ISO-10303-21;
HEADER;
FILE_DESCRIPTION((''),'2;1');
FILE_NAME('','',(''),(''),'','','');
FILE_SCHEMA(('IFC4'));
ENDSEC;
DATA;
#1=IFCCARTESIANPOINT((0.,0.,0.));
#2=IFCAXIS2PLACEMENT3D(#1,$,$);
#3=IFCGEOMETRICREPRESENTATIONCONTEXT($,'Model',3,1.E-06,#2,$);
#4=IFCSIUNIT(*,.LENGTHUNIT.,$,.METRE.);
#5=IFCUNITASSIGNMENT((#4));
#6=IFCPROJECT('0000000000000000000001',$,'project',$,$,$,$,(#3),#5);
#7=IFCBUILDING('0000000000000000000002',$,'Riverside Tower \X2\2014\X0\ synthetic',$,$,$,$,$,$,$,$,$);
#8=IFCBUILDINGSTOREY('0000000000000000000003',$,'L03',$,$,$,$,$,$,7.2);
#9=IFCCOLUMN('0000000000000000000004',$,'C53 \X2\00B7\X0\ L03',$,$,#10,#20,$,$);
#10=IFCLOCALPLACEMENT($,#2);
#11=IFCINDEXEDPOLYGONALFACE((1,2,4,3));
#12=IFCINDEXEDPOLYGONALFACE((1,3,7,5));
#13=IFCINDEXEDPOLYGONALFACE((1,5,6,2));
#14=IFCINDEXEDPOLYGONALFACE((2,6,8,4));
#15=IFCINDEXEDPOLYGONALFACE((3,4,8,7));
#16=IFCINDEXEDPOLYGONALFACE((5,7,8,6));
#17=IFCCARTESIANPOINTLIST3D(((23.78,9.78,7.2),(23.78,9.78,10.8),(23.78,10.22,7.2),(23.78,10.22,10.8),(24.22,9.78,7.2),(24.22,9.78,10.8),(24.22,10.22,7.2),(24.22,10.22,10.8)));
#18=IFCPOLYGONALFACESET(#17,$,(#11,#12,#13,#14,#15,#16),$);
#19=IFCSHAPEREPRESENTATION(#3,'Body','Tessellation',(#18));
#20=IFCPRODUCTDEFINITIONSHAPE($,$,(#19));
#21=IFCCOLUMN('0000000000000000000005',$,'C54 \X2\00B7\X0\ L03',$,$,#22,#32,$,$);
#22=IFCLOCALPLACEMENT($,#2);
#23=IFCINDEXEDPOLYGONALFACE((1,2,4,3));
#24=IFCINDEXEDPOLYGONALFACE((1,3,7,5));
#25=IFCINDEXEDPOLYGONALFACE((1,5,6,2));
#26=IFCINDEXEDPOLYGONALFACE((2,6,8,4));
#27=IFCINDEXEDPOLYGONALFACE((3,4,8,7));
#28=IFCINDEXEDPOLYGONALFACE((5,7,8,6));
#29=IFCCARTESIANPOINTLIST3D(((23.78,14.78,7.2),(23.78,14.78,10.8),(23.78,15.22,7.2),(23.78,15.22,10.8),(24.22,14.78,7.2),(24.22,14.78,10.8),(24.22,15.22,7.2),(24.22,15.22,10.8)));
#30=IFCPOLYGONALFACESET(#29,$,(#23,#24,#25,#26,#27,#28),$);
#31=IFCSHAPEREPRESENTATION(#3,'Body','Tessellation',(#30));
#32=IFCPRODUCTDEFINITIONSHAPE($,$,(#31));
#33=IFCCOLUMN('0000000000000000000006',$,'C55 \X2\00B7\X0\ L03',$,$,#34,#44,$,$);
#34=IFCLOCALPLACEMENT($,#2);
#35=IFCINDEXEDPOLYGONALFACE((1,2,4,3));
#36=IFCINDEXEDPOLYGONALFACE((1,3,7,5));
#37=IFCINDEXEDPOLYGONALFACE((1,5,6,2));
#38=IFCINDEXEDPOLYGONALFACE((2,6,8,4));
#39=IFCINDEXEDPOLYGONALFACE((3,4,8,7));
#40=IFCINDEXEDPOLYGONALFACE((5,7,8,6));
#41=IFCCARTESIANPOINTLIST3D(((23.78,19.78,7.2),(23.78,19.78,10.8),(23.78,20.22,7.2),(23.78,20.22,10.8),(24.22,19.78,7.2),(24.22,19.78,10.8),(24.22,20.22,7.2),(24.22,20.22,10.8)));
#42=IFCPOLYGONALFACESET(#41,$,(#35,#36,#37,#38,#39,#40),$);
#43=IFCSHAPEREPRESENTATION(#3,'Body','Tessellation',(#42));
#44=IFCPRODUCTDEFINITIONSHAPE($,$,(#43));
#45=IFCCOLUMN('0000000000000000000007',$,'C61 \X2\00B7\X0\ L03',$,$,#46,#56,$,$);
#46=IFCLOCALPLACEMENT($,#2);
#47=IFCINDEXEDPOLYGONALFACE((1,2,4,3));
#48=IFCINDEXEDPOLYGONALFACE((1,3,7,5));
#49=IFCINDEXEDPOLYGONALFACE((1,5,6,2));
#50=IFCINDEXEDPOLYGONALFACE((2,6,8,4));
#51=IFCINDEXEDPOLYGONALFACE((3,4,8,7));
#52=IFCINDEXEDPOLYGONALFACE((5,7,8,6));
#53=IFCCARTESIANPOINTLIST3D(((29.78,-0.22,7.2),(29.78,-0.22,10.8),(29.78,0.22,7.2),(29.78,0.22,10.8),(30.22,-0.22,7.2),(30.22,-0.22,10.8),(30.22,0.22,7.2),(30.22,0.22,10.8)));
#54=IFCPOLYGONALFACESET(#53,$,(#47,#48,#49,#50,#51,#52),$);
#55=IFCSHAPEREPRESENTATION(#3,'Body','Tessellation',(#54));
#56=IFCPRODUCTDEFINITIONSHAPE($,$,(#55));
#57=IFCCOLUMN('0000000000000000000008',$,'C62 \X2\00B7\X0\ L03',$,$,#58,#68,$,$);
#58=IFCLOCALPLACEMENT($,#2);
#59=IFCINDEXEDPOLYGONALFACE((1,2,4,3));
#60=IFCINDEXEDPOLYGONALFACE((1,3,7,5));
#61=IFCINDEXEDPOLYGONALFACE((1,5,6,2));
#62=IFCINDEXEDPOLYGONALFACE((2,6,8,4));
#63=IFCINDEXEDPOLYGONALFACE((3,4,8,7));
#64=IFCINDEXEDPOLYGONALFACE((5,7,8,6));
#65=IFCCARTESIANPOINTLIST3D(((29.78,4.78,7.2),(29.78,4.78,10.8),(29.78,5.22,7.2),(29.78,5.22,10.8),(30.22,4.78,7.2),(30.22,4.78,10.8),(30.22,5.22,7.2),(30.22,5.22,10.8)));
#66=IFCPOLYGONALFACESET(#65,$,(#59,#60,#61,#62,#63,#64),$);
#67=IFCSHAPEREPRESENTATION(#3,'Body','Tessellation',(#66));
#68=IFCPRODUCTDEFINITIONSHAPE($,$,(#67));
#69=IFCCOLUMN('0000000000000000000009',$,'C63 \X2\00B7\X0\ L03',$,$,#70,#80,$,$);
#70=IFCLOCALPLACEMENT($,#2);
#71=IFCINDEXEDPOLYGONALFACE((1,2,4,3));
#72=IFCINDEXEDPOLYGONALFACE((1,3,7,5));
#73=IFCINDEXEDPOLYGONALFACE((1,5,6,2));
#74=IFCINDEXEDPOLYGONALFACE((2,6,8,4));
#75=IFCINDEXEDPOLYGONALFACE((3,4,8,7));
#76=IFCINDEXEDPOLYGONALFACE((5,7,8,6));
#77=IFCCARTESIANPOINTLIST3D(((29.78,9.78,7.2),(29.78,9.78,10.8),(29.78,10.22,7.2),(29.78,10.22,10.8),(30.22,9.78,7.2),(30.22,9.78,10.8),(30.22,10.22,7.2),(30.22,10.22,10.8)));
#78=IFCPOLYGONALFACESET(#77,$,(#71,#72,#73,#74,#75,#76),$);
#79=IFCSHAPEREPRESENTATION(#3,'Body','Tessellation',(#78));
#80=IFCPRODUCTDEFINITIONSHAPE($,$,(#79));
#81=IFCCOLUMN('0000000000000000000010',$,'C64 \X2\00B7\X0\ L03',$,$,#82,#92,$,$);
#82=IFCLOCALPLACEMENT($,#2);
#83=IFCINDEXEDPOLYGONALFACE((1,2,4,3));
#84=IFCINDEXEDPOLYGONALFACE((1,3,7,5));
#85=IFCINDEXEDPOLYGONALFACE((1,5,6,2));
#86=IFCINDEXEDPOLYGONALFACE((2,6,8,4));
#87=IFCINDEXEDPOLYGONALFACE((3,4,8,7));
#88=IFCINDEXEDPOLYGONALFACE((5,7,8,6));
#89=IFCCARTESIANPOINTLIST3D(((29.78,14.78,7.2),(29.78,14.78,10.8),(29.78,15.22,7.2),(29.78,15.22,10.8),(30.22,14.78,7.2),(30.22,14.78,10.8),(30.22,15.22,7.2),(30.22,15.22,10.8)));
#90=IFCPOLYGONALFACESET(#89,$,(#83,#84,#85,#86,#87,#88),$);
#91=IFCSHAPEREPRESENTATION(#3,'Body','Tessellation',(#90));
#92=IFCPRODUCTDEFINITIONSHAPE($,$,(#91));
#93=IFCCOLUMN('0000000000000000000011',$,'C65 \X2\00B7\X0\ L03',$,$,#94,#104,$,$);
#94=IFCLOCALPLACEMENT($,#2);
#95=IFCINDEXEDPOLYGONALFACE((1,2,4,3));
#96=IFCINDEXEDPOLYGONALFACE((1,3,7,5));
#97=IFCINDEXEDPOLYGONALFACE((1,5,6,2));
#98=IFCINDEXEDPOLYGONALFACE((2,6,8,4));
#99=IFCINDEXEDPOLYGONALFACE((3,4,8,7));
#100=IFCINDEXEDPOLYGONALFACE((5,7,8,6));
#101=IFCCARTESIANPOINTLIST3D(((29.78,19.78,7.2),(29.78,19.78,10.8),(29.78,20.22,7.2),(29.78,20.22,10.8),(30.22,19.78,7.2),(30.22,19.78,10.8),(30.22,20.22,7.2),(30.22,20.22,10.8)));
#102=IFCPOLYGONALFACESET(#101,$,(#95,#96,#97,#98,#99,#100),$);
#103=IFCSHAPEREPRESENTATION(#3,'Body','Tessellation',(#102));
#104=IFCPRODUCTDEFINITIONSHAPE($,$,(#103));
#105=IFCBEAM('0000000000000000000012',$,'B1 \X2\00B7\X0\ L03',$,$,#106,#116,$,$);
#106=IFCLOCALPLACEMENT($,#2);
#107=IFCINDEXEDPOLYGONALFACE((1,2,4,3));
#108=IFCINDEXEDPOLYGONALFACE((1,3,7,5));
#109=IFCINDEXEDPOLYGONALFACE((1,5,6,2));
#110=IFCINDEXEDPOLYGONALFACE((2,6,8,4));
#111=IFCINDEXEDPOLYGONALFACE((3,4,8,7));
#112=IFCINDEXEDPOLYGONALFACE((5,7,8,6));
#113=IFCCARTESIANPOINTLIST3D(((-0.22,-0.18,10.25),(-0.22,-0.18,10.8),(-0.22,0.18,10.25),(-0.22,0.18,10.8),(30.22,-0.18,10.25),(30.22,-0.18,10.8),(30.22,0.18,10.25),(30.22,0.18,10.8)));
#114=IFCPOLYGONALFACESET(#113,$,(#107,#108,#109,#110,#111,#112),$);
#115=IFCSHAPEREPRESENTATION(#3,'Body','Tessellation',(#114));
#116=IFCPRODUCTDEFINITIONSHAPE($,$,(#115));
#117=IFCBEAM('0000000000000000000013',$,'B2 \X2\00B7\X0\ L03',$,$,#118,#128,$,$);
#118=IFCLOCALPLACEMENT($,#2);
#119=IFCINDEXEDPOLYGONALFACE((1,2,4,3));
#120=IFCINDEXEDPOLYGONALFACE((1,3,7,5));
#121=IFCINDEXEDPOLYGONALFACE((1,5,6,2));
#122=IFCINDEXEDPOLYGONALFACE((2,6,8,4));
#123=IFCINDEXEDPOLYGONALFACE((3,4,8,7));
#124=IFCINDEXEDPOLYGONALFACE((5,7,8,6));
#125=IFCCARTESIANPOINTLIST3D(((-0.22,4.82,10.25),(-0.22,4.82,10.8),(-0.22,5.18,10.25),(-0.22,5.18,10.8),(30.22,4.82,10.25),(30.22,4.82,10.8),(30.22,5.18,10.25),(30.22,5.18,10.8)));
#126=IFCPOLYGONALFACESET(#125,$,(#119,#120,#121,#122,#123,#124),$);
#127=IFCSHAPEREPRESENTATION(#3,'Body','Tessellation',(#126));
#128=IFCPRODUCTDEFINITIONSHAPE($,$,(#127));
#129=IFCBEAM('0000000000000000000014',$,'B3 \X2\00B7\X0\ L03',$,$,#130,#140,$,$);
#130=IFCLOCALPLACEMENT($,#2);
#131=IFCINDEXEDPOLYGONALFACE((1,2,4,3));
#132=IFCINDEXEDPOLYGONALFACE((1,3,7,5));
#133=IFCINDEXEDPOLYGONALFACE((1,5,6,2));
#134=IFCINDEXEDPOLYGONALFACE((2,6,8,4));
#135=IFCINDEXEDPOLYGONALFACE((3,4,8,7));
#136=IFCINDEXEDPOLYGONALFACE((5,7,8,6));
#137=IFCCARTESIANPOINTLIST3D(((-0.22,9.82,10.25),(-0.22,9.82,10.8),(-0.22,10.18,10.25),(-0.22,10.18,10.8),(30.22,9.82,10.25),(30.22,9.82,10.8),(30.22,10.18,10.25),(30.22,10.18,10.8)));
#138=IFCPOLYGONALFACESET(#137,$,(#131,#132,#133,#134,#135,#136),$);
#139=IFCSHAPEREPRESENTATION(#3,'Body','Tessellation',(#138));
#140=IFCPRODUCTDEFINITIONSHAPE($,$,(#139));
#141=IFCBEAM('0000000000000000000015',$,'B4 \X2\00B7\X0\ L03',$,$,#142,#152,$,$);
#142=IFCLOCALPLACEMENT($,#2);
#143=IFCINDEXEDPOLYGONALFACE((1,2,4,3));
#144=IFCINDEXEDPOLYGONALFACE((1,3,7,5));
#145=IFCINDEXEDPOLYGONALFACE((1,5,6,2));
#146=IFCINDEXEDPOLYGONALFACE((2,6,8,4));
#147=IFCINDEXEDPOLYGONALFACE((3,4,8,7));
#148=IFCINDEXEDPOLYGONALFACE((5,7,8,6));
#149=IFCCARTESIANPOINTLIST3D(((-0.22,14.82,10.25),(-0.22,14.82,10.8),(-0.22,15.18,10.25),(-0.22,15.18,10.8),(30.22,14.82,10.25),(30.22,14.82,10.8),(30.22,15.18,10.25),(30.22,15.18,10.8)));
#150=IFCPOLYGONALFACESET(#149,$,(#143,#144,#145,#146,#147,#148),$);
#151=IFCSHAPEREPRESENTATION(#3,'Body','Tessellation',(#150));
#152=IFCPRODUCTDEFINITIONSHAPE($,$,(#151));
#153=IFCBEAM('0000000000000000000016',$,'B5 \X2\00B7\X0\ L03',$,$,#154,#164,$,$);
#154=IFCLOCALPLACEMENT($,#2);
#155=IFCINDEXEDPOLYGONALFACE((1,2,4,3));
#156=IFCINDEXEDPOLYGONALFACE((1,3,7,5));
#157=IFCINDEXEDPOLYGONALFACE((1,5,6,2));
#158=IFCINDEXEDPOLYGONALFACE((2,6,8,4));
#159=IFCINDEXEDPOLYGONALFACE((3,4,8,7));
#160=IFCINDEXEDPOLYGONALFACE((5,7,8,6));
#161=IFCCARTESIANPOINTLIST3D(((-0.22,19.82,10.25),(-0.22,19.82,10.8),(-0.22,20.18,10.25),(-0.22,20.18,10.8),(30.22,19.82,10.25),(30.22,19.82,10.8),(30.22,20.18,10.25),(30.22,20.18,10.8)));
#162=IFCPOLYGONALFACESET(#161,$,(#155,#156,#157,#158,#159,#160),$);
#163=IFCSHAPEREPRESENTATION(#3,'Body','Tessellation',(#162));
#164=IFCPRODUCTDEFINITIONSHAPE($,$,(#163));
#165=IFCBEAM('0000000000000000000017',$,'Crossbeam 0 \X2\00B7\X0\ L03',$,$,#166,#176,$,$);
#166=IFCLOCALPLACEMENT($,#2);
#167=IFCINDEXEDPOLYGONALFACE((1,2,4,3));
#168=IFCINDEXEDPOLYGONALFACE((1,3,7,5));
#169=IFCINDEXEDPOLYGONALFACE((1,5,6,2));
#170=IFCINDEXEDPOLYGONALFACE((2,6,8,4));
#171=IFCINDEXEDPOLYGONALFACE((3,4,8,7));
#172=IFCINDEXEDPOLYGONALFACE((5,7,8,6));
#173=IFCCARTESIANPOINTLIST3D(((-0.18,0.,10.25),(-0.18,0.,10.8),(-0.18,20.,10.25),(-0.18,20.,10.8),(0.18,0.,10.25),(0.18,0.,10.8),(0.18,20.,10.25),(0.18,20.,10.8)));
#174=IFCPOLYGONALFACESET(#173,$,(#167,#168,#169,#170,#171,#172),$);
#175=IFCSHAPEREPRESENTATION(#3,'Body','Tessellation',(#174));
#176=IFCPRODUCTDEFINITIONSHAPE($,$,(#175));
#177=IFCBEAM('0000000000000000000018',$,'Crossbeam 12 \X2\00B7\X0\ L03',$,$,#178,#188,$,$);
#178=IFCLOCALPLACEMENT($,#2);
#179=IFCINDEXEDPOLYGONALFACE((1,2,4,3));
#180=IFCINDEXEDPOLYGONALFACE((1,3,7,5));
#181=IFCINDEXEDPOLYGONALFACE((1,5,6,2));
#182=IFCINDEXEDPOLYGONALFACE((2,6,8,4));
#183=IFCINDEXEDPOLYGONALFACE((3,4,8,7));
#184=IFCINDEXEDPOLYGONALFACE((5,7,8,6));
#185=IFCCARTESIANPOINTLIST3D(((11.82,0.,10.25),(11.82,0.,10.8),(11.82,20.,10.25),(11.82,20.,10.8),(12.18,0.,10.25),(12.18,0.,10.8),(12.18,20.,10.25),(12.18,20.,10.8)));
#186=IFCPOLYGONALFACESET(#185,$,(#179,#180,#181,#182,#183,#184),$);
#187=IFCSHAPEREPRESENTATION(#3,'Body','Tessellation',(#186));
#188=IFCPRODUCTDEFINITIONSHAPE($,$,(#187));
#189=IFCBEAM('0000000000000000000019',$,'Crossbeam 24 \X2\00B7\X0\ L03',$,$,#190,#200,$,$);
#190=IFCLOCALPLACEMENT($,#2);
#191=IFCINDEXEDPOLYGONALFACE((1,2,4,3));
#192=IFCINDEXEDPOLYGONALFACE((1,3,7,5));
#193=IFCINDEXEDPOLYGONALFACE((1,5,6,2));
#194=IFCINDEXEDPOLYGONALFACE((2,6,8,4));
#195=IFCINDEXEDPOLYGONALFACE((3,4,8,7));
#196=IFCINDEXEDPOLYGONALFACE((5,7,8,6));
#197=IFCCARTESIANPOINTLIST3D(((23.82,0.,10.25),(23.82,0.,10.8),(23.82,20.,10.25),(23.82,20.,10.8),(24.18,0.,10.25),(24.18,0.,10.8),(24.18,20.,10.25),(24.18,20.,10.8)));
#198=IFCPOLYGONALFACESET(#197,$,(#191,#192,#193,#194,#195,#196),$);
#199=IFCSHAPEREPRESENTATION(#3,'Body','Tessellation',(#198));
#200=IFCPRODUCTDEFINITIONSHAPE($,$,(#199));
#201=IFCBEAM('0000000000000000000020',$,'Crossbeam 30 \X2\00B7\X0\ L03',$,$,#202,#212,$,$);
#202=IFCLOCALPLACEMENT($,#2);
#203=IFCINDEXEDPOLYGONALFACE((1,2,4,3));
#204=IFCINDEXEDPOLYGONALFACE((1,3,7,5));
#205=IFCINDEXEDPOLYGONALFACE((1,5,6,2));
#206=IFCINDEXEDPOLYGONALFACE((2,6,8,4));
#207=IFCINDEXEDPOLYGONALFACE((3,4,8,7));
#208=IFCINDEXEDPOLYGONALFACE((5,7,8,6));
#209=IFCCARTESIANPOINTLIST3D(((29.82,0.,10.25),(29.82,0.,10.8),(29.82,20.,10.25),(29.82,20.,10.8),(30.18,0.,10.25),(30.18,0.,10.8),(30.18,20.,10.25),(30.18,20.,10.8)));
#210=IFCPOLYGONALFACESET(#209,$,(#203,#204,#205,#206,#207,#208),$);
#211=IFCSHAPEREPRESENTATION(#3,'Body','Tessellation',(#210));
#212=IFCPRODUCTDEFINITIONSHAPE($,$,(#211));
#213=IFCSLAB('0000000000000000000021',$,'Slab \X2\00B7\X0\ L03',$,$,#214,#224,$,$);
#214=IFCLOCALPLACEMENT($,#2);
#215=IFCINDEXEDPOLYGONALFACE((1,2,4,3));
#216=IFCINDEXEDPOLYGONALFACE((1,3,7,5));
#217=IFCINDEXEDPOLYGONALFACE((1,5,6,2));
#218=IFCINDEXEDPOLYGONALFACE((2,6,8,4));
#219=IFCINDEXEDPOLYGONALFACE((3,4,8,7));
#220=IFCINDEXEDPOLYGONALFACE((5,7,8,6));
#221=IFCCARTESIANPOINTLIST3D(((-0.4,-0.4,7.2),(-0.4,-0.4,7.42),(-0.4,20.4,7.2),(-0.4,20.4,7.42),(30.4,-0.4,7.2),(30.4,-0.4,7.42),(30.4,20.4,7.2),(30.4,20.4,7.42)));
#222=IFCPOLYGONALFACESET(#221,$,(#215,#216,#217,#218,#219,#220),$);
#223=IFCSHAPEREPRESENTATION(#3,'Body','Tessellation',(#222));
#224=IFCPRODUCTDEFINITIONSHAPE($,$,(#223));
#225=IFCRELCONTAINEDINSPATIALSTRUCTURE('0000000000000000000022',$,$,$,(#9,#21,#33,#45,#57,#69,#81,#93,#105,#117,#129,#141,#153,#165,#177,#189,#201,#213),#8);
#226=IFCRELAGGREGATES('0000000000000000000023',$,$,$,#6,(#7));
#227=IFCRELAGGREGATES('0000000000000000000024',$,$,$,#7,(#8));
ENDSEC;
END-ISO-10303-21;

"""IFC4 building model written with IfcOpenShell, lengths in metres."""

from ifc_helpers import new_model, si_unit, frame, origin, place, context, project, spatial, rectangle, extrude, element, save


model = new_model("IFC4")

# Units and contexts
model_context = context("Model", 3, precision=1e-06, world=origin())
ifc_project = project(units=[si_unit("LENGTHUNIT", "METRE")], contexts=[model_context])

# Building, storey
building = spatial("IfcBuilding", under=ifc_project, Name="Riverside Tower — synthetic")
storey = spatial("IfcBuildingStorey", under=building, Name="L03", Elevation=7.2)

# Columns
for number, where, name in (
    (1, (24.0, 10.0, 7.2), "C53 · L03"),
    (2, (24.0, 15.0, 7.2), "C54 · L03"),
    (3, (24.0, 20.0, 7.2), "C55 · L03"),
    (4, (30.0, 0.0, 7.2), "C61 · L03"),
    (5, (30.0, 5.0, 7.2), "C62 · L03"),
    (6, (30.0, 10.0, 7.2), "C63 · L03"),
    (7, (30.0, 15.0, 7.2), "C64 · L03"),
    (8, (30.0, 20.0, 7.2), "C65 · L03"),
):
    element("IfcColumn", number, at=place(None, frame(where)), inside=storey, Name=name, context=model_context, shape_type="SweptSolid", body=[
        extrude(rectangle(XDim=0.44, YDim=0.44), origin(), (0.0, 0.0, 1.0), 3.6),
    ])

# Beams
for number, where, name in (
    (9, (15.0, 0.0, 10.25), "B1 · L03"),
    (10, (15.0, 5.0, 10.25), "B2 · L03"),
    (11, (15.0, 10.0, 10.25), "B3 · L03"),
    (12, (15.0, 15.0, 10.25), "B4 · L03"),
    (13, (15.0, 20.0, 10.25), "B5 · L03"),
):
    element("IfcBeam", number, at=place(None, frame(where)), inside=storey, Name=name, context=model_context, shape_type="SweptSolid", body=[
        extrude(rectangle(XDim=30.44, YDim=0.36), origin(), (0.0, 0.0, 1.0), 0.55),
    ])
for number, where, name in (
    (14, (0.0, 10.0, 10.25), "Crossbeam 0 · L03"),
    (15, (12.0, 10.0, 10.25), "Crossbeam 12 · L03"),
    (16, (24.0, 10.0, 10.25), "Crossbeam 24 · L03"),
    (17, (30.0, 10.0, 10.25), "Crossbeam 30 · L03"),
):
    element("IfcBeam", number, at=place(None, frame(where)), inside=storey, Name=name, context=model_context, shape_type="SweptSolid", body=[
        extrude(rectangle(XDim=0.36, YDim=20.0), origin(), (0.0, 0.0, 1.0), 0.55),
    ])

# Slab
slab_placement = place(None, frame((15.0, 10.0, 7.2)))
element("IfcSlab", 18, at=slab_placement, inside=storey, Name="Slab · L03", context=model_context, shape_type="SweptSolid", body=[
    extrude(rectangle(XDim=30.8, YDim=20.8), origin(), (0.0, 0.0, 1.0), 0.22),
])

save(model, "model.ifc")
